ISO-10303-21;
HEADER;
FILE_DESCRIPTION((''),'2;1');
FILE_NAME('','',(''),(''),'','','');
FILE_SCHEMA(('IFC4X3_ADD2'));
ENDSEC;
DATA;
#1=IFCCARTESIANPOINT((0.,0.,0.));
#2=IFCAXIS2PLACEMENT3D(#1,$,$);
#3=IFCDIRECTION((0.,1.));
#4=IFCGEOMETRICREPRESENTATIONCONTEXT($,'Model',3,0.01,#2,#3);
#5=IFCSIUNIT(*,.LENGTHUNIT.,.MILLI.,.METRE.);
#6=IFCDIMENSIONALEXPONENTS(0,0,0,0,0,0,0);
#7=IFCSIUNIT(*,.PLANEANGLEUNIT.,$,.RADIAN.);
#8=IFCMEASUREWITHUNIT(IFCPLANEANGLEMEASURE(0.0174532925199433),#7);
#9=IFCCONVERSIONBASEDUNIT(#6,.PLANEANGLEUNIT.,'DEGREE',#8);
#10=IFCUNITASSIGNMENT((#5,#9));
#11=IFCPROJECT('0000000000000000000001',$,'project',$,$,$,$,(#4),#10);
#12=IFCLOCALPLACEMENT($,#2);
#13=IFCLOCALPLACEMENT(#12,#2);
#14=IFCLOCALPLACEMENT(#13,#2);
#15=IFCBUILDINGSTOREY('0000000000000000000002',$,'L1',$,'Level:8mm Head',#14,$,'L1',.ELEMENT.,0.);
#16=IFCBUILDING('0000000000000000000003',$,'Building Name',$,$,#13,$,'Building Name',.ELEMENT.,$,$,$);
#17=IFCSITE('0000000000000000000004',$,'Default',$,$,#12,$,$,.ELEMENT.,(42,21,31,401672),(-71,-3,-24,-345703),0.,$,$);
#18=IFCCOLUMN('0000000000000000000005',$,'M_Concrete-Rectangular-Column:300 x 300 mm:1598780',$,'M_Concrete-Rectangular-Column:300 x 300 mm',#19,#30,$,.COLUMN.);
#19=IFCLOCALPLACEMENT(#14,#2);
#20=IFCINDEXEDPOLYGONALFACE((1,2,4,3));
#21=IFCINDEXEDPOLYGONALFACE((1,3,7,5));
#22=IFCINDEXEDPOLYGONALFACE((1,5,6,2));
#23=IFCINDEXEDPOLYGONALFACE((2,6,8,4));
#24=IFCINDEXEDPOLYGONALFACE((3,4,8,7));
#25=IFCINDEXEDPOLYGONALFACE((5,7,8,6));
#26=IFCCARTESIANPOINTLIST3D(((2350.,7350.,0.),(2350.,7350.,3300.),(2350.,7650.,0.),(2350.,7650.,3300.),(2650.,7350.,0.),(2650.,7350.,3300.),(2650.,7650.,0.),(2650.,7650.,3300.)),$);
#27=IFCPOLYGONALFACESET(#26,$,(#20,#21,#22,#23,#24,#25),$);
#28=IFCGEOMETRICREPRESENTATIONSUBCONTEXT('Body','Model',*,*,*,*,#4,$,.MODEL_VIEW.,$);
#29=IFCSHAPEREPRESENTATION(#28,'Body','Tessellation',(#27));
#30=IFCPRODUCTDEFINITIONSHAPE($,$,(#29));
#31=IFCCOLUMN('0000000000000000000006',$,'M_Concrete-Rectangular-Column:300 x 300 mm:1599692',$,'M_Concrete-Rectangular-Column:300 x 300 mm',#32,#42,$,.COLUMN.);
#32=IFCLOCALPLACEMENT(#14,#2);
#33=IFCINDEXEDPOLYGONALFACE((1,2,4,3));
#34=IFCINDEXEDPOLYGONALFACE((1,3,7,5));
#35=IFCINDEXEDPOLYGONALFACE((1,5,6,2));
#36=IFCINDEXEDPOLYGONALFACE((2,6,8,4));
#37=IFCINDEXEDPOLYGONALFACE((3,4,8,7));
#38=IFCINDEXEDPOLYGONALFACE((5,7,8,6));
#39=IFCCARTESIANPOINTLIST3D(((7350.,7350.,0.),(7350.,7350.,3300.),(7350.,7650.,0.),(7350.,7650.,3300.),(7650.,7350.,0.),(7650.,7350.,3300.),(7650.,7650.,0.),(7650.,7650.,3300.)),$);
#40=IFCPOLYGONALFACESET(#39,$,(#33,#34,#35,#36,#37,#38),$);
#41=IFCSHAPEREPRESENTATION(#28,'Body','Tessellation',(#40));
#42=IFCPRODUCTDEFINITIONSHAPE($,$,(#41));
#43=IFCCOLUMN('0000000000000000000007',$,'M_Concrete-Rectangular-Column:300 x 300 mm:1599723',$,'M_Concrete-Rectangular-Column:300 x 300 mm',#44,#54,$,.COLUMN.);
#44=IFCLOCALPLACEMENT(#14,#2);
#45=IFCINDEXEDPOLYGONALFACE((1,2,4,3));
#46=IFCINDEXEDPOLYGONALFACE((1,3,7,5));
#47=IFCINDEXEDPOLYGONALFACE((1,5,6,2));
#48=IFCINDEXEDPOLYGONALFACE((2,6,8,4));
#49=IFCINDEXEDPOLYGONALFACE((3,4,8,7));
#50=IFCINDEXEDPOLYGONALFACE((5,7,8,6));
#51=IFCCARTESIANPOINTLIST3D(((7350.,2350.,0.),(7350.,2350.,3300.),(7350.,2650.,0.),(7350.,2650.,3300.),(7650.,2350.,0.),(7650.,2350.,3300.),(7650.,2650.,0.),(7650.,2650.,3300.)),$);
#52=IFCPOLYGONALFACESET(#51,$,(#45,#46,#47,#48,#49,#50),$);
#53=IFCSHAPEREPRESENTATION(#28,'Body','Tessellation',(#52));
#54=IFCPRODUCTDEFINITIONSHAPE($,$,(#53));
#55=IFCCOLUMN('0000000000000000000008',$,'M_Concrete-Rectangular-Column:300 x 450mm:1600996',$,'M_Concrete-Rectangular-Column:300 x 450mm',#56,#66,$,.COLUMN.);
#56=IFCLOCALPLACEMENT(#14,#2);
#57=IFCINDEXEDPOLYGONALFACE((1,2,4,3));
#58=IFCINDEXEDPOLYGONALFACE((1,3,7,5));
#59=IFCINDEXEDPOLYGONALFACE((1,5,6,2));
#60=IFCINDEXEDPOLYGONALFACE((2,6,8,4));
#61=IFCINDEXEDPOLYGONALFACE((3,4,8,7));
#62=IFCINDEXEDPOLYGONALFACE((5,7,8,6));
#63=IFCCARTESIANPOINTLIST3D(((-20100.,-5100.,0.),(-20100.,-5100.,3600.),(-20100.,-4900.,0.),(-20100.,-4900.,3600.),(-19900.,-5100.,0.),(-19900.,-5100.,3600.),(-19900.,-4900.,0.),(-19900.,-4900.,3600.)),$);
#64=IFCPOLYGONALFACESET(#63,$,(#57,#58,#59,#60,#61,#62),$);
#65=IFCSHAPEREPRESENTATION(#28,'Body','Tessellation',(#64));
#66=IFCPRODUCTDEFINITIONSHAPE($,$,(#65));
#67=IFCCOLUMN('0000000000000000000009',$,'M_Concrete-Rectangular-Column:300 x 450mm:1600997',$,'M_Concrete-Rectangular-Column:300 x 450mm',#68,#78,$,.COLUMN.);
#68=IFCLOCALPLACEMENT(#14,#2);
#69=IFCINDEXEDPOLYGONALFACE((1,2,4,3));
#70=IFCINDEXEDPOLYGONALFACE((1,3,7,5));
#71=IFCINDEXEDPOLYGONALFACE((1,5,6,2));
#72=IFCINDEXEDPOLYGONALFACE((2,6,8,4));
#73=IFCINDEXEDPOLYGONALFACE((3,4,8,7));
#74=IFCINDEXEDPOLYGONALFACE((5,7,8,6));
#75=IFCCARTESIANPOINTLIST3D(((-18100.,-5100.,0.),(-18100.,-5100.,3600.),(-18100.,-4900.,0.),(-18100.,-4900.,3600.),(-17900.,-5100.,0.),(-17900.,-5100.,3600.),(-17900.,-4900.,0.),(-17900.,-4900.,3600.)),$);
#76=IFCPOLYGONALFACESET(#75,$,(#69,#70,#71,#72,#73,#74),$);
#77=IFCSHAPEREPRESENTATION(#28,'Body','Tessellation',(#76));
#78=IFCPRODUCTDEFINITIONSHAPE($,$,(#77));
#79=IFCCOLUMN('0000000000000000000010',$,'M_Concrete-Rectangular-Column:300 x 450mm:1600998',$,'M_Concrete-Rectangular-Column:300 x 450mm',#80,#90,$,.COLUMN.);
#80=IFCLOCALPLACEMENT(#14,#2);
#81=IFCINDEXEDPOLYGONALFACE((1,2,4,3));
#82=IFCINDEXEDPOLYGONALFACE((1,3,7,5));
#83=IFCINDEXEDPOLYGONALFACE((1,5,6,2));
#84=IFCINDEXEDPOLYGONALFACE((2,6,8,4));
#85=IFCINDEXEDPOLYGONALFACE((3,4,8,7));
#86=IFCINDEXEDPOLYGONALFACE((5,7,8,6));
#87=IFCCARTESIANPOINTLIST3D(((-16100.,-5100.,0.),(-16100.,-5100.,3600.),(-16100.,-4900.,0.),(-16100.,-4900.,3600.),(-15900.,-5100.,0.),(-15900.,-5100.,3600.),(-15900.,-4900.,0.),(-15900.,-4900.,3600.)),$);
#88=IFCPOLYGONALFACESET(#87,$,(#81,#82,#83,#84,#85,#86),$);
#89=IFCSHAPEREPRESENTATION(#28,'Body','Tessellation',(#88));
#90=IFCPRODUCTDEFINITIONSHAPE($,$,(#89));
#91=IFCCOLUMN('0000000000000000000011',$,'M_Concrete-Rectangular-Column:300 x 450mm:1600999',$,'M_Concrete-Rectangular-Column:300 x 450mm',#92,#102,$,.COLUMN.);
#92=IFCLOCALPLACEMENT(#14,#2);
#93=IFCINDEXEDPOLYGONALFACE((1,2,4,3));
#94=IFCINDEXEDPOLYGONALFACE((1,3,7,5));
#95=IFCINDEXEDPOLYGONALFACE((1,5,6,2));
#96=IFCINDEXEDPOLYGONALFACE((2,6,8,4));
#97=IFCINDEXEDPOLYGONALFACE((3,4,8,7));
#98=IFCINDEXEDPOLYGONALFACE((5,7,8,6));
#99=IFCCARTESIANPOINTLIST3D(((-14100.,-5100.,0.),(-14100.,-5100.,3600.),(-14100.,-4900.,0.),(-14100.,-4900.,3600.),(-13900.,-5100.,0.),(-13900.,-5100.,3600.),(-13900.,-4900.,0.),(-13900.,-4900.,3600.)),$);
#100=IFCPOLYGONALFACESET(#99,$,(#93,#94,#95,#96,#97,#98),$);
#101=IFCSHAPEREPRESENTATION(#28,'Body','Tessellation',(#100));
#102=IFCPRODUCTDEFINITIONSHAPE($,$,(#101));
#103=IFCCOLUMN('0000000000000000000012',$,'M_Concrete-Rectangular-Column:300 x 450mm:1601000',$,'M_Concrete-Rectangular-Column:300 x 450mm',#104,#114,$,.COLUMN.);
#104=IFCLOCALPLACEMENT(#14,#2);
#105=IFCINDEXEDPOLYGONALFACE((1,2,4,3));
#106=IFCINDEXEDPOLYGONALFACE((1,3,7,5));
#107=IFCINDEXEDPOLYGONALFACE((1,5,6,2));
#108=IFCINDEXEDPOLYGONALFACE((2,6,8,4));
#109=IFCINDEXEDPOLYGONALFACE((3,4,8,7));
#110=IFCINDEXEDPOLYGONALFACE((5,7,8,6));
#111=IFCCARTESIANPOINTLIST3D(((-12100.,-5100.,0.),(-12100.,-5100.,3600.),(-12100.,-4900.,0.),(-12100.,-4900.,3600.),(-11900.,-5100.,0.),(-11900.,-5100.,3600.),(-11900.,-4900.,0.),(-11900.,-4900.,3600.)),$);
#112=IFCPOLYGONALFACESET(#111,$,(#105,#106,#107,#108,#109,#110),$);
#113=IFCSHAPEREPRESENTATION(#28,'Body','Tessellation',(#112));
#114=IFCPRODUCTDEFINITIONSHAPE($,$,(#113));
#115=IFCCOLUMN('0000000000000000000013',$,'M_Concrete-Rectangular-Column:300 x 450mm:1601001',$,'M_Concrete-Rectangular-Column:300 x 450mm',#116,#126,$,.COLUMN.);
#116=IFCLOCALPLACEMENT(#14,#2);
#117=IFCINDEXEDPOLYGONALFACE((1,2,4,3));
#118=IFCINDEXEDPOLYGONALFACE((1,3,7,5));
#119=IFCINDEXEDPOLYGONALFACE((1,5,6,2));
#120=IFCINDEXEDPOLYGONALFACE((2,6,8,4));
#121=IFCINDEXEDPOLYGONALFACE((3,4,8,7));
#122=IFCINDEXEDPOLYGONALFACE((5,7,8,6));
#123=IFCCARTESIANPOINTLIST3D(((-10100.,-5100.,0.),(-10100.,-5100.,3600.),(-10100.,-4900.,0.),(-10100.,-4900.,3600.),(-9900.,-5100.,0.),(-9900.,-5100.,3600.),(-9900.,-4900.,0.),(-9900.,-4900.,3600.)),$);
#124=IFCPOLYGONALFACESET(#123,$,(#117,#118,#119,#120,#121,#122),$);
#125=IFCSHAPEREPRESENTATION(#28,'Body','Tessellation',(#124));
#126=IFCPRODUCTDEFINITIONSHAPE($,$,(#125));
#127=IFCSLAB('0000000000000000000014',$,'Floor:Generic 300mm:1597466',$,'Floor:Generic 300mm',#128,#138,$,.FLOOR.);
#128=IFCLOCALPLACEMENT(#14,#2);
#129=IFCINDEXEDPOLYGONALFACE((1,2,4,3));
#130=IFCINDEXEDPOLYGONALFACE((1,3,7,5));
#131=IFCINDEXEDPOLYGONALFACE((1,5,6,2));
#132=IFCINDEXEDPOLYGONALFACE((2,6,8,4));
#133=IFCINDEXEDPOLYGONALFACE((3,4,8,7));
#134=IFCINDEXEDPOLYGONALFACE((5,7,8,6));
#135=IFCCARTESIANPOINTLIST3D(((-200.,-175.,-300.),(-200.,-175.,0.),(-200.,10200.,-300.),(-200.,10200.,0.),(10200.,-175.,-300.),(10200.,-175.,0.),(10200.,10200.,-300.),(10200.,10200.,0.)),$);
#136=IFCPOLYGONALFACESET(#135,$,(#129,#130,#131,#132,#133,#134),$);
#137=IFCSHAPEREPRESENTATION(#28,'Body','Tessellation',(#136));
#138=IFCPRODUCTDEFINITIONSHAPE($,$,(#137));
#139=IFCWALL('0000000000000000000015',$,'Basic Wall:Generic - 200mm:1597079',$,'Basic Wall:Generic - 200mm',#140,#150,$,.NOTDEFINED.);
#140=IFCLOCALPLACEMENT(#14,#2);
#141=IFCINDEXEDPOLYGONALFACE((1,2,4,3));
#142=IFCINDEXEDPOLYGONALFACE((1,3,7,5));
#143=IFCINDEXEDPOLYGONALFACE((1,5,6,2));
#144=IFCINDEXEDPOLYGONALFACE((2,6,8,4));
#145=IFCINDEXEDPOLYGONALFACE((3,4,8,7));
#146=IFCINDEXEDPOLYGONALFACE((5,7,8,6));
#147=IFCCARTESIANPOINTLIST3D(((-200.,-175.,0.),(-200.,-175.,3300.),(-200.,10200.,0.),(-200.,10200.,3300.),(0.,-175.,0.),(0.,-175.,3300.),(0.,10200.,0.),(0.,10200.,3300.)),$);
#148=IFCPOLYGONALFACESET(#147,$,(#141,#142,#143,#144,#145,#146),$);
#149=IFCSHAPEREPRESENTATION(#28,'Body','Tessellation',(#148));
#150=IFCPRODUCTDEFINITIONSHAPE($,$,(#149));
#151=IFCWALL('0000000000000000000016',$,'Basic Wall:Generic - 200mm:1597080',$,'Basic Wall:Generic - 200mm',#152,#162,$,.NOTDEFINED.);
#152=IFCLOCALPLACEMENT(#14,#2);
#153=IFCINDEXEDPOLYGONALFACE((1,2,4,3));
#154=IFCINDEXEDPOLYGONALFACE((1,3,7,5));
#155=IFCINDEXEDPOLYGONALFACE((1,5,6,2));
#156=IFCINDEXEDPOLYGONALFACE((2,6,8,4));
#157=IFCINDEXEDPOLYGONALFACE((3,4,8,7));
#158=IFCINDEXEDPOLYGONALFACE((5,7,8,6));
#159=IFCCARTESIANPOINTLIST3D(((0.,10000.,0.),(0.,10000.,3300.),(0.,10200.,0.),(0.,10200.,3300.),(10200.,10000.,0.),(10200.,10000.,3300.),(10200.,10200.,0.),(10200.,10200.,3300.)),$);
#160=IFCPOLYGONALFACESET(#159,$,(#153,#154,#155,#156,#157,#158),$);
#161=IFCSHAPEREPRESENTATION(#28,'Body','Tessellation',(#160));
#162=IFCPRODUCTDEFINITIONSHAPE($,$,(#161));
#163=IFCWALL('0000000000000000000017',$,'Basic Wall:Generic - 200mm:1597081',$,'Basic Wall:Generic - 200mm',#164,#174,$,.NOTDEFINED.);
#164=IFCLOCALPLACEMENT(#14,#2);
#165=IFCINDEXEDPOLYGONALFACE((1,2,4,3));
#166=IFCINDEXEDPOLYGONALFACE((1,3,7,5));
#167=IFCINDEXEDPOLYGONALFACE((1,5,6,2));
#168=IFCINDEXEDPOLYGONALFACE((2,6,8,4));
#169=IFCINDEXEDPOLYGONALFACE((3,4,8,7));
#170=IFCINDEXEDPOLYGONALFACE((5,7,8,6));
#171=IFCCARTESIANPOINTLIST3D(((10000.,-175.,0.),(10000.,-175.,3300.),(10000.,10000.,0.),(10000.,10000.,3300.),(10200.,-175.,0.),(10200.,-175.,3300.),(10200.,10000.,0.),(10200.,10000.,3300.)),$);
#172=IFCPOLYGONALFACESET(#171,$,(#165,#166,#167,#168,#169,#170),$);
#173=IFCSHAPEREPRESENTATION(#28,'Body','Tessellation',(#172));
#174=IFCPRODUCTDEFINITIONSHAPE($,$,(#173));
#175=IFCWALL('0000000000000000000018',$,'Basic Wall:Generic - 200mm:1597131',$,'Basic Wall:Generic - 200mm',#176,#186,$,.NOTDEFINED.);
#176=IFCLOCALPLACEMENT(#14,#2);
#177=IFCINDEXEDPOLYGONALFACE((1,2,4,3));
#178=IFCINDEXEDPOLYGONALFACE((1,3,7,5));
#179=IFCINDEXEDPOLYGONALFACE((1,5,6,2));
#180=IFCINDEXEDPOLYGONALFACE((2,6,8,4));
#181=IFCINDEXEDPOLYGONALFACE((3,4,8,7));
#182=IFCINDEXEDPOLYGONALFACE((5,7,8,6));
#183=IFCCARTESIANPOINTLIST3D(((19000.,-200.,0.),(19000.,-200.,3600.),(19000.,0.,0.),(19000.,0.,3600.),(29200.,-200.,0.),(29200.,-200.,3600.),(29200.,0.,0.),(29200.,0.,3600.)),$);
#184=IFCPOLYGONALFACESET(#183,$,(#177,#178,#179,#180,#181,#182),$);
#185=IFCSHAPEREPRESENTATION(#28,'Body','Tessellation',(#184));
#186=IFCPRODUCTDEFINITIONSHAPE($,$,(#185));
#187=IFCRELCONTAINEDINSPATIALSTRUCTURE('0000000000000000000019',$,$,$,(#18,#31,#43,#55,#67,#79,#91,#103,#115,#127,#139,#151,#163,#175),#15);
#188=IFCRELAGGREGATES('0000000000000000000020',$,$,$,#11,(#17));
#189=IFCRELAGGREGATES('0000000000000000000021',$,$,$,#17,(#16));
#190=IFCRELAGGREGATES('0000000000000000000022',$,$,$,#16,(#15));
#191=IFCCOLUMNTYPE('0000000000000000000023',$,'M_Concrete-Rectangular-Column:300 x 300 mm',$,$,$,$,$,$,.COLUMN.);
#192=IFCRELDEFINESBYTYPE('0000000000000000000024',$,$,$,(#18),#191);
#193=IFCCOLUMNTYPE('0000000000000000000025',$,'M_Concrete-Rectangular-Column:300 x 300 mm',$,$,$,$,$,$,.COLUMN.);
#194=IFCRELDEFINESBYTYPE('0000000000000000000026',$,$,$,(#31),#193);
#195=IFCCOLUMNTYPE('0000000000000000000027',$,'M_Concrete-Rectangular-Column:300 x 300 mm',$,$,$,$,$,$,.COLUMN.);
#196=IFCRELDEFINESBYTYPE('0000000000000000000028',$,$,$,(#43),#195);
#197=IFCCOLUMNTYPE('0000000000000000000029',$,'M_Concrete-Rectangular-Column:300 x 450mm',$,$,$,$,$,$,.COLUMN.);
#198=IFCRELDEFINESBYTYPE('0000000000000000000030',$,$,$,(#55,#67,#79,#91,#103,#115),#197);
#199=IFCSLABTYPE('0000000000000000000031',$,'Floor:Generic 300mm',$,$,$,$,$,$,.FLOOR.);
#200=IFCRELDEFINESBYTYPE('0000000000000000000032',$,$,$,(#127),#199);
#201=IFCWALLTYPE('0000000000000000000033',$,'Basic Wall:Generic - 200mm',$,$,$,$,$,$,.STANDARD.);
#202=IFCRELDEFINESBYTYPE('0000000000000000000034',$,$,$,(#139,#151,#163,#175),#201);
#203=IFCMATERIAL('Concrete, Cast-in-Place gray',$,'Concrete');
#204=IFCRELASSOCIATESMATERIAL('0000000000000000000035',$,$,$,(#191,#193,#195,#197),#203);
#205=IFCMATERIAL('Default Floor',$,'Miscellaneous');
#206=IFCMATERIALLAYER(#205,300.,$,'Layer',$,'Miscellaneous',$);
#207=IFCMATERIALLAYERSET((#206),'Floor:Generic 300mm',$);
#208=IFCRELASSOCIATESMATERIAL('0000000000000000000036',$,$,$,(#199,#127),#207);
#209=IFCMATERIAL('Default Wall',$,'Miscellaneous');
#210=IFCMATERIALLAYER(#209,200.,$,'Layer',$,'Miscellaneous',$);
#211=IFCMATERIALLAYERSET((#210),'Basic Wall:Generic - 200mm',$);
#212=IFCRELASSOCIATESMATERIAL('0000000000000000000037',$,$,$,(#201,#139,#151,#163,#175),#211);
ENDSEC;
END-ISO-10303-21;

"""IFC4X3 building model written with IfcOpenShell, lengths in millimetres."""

from ifc_helpers import new_model, entity, si_unit, converted_unit, direction, frame, frame_2d, origin, origin_2d_with_axis, place, context, subcontext, project, spatial, rectangle, extrude, source, transform, mapped, material, layer, layer_set, layer_usage, material_profile, profile_set, type_object, type_shapes, element, save


model = new_model("IFC4X3")

# Units and contexts
model_context = context("Model", 3, precision=0.01, world=origin(), true_north=direction((0.0, 1.0)))
body_context = subcontext(model_context, "Body", "Model", "MODEL_VIEW")
ifc_project = project(units=[si_unit("LENGTHUNIT", "METRE", prefix="MILLI"), converted_unit("PLANEANGLEUNIT", "DEGREE", entity("IfcPlaneAngleMeasure", 0.0174532925199433), si_unit("PLANEANGLEUNIT", "RADIAN"), dimensions=[0, 0, 0, 0, 0, 0, 0])], contexts=[model_context])

# Site, building, storey
site_placement = place(None, origin())
site = spatial("IfcSite", under=ifc_project, at=site_placement, Name="Default", CompositionType="ELEMENT", RefLatitude=(42, 21, 31, 401672), RefLongitude=(-71, -3, -24, -345703), RefElevation=0.0)
building_placement = place(site_placement, origin())
building = spatial("IfcBuilding", under=site, at=building_placement, Name="Building Name", LongName="Building Name", CompositionType="ELEMENT")
storey_placement = place(building_placement, origin())
storey = spatial("IfcBuildingStorey", under=building, at=storey_placement, Name="L1", ObjectType="Level:8mm Head", LongName="L1", CompositionType="ELEMENT", Elevation=0.0)

# Columns
ifc_material_1 = material(Name="Concrete, Cast-in-Place gray", Category="Concrete")
ifc_material_profile_1 = material_profile(ifc_material_1, rectangle(XDim=300.0, YDim=300.0, at=origin_2d_with_axis()), Name="300 x 300 mm")
ifc_profile_set_1 = profile_set([ifc_material_profile_1], Name="300 x 300 mm")
column_type_1 = type_object("IfcColumnType", Name="M_Concrete-Rectangular-Column:300 x 300 mm", PredefinedType="COLUMN", material=ifc_profile_set_1)
shared_shape_1 = source(origin(), body_context, "Body", "SweptSolid", [
    extrude(rectangle(XDim=300.0, YDim=300.0, at=origin_2d_with_axis()), frame((2500.0, 7500.0, 0.0)), (0.0, 0.0, 1.0), 3300.0),
])
type_shapes(column_type_1, [shared_shape_1])
column_1_placement = place(storey_placement, origin())
element("IfcColumn", 1, at=column_1_placement, inside=storey, type_object=column_type_1, Name="M_Concrete-Rectangular-Column:300 x 300 mm:1598780", ObjectType="M_Concrete-Rectangular-Column:300 x 300 mm", PredefinedType="COLUMN", context=body_context, shape_type="MappedRepresentation", body=[
    mapped(shared_shape_1, transform((0.0, 0.0, 0.0), scale=1.0)),
])
column_type_2 = type_object("IfcColumnType", Name="M_Concrete-Rectangular-Column:300 x 300 mm", PredefinedType="COLUMN", material=ifc_profile_set_1)
shared_shape_2 = source(origin(), body_context, "Body", "SweptSolid", [
    extrude(rectangle(XDim=300.0, YDim=300.0, at=origin_2d_with_axis()), frame((7500.0, 7500.0, 0.0)), (0.0, 0.0, 1.0), 3300.0),
])
type_shapes(column_type_2, [shared_shape_2])
column_2_placement = place(storey_placement, origin())
element("IfcColumn", 2, at=column_2_placement, inside=storey, type_object=column_type_2, Name="M_Concrete-Rectangular-Column:300 x 300 mm:1599692", ObjectType="M_Concrete-Rectangular-Column:300 x 300 mm", PredefinedType="COLUMN", context=body_context, shape_type="MappedRepresentation", body=[
    mapped(shared_shape_2, transform((0.0, 0.0, 0.0), scale=1.0)),
])
column_type_3 = type_object("IfcColumnType", Name="M_Concrete-Rectangular-Column:300 x 300 mm", PredefinedType="COLUMN", material=ifc_profile_set_1)
shared_shape_3 = source(origin(), body_context, "Body", "SweptSolid", [
    extrude(rectangle(XDim=300.0, YDim=300.0, at=origin_2d_with_axis()), frame((7500.0, 2500.0, 0.0)), (0.0, 0.0, 1.0), 3300.0),
])
type_shapes(column_type_3, [shared_shape_3])
column_3_placement = place(storey_placement, origin())
element("IfcColumn", 3, at=column_3_placement, inside=storey, type_object=column_type_3, Name="M_Concrete-Rectangular-Column:300 x 300 mm:1599723", ObjectType="M_Concrete-Rectangular-Column:300 x 300 mm", PredefinedType="COLUMN", context=body_context, shape_type="MappedRepresentation", body=[
    mapped(shared_shape_3, transform((0.0, 0.0, 0.0), scale=1.0)),
])
ifc_material_profile_2 = material_profile(ifc_material_1, rectangle(XDim=200.0, YDim=200.0, at=origin_2d_with_axis()), Name="300 x 450mm")
ifc_profile_set_2 = profile_set([ifc_material_profile_2], Name="300 x 450mm")
column_type_4 = type_object("IfcColumnType", Name="M_Concrete-Rectangular-Column:300 x 450mm", PredefinedType="COLUMN", material=ifc_profile_set_2)
shared_shape_4 = source(origin(), body_context, "Body", "SweptSolid", [
    extrude(rectangle(XDim=200.0, YDim=200.0, at=origin_2d_with_axis()), frame((0.0, 0.0, 0.0), z_axis=(0.0, 0.0, 1.0), x_axis=(-1.0, 0.0, 0.0)), (0.0, 0.0, 1.0), 3600.0),
])
type_shapes(column_type_4, [shared_shape_4])
for number, where, z_axis, x_axis, name in (
    (4, (-20000.0, -5000.0, 0.0), (0.0, 0.0, 1.0), (0.0, -1.0, 0.0), "M_Concrete-Rectangular-Column:300 x 450mm:1600996"),
    (5, (-18000.0, -5000.0, 0.0), (0.0, 0.0, 1.0), (0.0, -1.0, 0.0), "M_Concrete-Rectangular-Column:300 x 450mm:1600997"),
    (6, (-16000.0, -5000.0, 0.0), (0.0, 0.0, 1.0), (0.0, -1.0, 0.0), "M_Concrete-Rectangular-Column:300 x 450mm:1600998"),
    (7, (-14000.0, -5000.0, 0.0), (0.0, 0.0, 1.0), (0.0, -1.0, 0.0), "M_Concrete-Rectangular-Column:300 x 450mm:1600999"),
    (8, (-12000.0, -5000.0, 0.0), (0.0, 0.0, 1.0), (0.0, -1.0, 0.0), "M_Concrete-Rectangular-Column:300 x 450mm:1601000"),
    (9, (-10000.0, -5000.0, 0.0), (0.0, 0.0, 1.0), (0.0, -1.0, 0.0), "M_Concrete-Rectangular-Column:300 x 450mm:1601001"),
):
    element("IfcColumn", number, at=place(storey_placement, frame(where, z_axis=z_axis, x_axis=x_axis)), inside=storey, type_object=column_type_4, Name=name, ObjectType="M_Concrete-Rectangular-Column:300 x 450mm", PredefinedType="COLUMN", context=body_context, shape_type="MappedRepresentation", body=[
        mapped(shared_shape_4, transform((0.0, 0.0, 0.0), scale=1.0)),
    ])

# Slab
ifc_material_2 = material(Name="Default Floor", Category="Miscellaneous")
ifc_layer_1 = layer(ifc_material_2, 300.0, Name="Layer", Category="Miscellaneous")
ifc_layer_set_1 = layer_set([ifc_layer_1], Name="Floor:Generic 300mm")
ifc_layer_usage = layer_usage(ifc_layer_set_1, "AXIS3", "POSITIVE", 0.0)
slab_type = type_object("IfcSlabType", Name="Floor:Generic 300mm", PredefinedType="FLOOR", material=ifc_layer_set_1)
slab_placement = place(storey_placement, origin())
element("IfcSlab", 10, at=slab_placement, inside=storey, type_object=slab_type, material=ifc_layer_usage, Name="Floor:Generic 300mm:1597466", ObjectType="Floor:Generic 300mm", PredefinedType="FLOOR", context=body_context, shape_type="SweptSolid", body=[
    extrude(rectangle(XDim=10375.0, YDim=10400.0, at=origin_2d_with_axis()), frame((5000.0, 5012.5, 0.0), z_axis=(0.0, 0.0, -1.0), x_axis=(0.0, 1.0, 0.0)), (0.0, 0.0, 1.0), 300.0),
])

# Walls
ifc_material_3 = material(Name="Default Wall", Category="Miscellaneous")
ifc_layer_2 = layer(ifc_material_3, 200.0, Name="Layer", Category="Miscellaneous")
ifc_layer_set_2 = layer_set([ifc_layer_2], Name="Basic Wall:Generic - 200mm")
wall_type_1 = type_object("IfcWallType", Name="Basic Wall:Generic - 200mm", PredefinedType="STANDARD", material=ifc_layer_set_2)
wall_1_placement = place(storey_placement, frame((-100.0, 10200.0, 0.0), z_axis=(0.0, 0.0, 1.0), x_axis=(0.0, -1.0, 0.0)))
element("IfcWall", 11, at=wall_1_placement, inside=storey, type_object=wall_type_1, material=ifc_layer_set_2, Name="Basic Wall:Generic - 200mm:1597079", ObjectType="Basic Wall:Generic - 200mm", PredefinedType="NOTDEFINED", context=body_context, shape_type="SweptSolid", body=[
    extrude(rectangle(XDim=10375.0, YDim=200.0, at=frame_2d((5187.5, 0.0), x_axis=(-1.0, 0.0))), origin(), (0.0, 0.0, 1.0), 3300.0),
])
wall_2_placement = place(storey_placement, frame((10200.0, 10100.0, 0.0), z_axis=(0.0, 0.0, 1.0), x_axis=(-1.0, 0.0, 0.0)))
element("IfcWall", 12, at=wall_2_placement, inside=storey, type_object=wall_type_1, material=ifc_layer_set_2, Name="Basic Wall:Generic - 200mm:1597080", ObjectType="Basic Wall:Generic - 200mm", PredefinedType="NOTDEFINED", context=body_context, shape_type="SweptSolid", body=[
    extrude(rectangle(XDim=10200.0, YDim=200.0, at=frame_2d((5100.0, 0.0), x_axis=(-1.0, 0.0))), origin(), (0.0, 0.0, 1.0), 3300.0),
])
wall_3_placement = place(storey_placement, frame((10100.0, -175.0, 0.0), z_axis=(0.0, 0.0, 1.0), x_axis=(0.0, 1.0, 0.0)))
element("IfcWall", 13, at=wall_3_placement, inside=storey, type_object=wall_type_1, material=ifc_layer_set_2, Name="Basic Wall:Generic - 200mm:1597081", ObjectType="Basic Wall:Generic - 200mm", PredefinedType="NOTDEFINED", context=body_context, shape_type="SweptSolid", body=[
    extrude(rectangle(XDim=10175.0, YDim=200.0, at=frame_2d((5087.5, 0.0), x_axis=(-1.0, 0.0))), origin(), (0.0, 0.0, 1.0), 3300.0),
])
wall_4_placement = place(storey_placement, frame((19000.0, -100.0, 0.0)))
element("IfcWall", 14, at=wall_4_placement, inside=storey, type_object=wall_type_1, material=ifc_layer_set_2, Name="Basic Wall:Generic - 200mm:1597131", ObjectType="Basic Wall:Generic - 200mm", PredefinedType="NOTDEFINED", context=body_context, shape_type="SweptSolid", body=[
    extrude(rectangle(XDim=10200.0, YDim=200.0, at=frame_2d((5100.0, 0.0), x_axis=(-1.0, 0.0))), origin(), (0.0, 0.0, 1.0), 3600.0),
])

save(model, "model.ifc")
